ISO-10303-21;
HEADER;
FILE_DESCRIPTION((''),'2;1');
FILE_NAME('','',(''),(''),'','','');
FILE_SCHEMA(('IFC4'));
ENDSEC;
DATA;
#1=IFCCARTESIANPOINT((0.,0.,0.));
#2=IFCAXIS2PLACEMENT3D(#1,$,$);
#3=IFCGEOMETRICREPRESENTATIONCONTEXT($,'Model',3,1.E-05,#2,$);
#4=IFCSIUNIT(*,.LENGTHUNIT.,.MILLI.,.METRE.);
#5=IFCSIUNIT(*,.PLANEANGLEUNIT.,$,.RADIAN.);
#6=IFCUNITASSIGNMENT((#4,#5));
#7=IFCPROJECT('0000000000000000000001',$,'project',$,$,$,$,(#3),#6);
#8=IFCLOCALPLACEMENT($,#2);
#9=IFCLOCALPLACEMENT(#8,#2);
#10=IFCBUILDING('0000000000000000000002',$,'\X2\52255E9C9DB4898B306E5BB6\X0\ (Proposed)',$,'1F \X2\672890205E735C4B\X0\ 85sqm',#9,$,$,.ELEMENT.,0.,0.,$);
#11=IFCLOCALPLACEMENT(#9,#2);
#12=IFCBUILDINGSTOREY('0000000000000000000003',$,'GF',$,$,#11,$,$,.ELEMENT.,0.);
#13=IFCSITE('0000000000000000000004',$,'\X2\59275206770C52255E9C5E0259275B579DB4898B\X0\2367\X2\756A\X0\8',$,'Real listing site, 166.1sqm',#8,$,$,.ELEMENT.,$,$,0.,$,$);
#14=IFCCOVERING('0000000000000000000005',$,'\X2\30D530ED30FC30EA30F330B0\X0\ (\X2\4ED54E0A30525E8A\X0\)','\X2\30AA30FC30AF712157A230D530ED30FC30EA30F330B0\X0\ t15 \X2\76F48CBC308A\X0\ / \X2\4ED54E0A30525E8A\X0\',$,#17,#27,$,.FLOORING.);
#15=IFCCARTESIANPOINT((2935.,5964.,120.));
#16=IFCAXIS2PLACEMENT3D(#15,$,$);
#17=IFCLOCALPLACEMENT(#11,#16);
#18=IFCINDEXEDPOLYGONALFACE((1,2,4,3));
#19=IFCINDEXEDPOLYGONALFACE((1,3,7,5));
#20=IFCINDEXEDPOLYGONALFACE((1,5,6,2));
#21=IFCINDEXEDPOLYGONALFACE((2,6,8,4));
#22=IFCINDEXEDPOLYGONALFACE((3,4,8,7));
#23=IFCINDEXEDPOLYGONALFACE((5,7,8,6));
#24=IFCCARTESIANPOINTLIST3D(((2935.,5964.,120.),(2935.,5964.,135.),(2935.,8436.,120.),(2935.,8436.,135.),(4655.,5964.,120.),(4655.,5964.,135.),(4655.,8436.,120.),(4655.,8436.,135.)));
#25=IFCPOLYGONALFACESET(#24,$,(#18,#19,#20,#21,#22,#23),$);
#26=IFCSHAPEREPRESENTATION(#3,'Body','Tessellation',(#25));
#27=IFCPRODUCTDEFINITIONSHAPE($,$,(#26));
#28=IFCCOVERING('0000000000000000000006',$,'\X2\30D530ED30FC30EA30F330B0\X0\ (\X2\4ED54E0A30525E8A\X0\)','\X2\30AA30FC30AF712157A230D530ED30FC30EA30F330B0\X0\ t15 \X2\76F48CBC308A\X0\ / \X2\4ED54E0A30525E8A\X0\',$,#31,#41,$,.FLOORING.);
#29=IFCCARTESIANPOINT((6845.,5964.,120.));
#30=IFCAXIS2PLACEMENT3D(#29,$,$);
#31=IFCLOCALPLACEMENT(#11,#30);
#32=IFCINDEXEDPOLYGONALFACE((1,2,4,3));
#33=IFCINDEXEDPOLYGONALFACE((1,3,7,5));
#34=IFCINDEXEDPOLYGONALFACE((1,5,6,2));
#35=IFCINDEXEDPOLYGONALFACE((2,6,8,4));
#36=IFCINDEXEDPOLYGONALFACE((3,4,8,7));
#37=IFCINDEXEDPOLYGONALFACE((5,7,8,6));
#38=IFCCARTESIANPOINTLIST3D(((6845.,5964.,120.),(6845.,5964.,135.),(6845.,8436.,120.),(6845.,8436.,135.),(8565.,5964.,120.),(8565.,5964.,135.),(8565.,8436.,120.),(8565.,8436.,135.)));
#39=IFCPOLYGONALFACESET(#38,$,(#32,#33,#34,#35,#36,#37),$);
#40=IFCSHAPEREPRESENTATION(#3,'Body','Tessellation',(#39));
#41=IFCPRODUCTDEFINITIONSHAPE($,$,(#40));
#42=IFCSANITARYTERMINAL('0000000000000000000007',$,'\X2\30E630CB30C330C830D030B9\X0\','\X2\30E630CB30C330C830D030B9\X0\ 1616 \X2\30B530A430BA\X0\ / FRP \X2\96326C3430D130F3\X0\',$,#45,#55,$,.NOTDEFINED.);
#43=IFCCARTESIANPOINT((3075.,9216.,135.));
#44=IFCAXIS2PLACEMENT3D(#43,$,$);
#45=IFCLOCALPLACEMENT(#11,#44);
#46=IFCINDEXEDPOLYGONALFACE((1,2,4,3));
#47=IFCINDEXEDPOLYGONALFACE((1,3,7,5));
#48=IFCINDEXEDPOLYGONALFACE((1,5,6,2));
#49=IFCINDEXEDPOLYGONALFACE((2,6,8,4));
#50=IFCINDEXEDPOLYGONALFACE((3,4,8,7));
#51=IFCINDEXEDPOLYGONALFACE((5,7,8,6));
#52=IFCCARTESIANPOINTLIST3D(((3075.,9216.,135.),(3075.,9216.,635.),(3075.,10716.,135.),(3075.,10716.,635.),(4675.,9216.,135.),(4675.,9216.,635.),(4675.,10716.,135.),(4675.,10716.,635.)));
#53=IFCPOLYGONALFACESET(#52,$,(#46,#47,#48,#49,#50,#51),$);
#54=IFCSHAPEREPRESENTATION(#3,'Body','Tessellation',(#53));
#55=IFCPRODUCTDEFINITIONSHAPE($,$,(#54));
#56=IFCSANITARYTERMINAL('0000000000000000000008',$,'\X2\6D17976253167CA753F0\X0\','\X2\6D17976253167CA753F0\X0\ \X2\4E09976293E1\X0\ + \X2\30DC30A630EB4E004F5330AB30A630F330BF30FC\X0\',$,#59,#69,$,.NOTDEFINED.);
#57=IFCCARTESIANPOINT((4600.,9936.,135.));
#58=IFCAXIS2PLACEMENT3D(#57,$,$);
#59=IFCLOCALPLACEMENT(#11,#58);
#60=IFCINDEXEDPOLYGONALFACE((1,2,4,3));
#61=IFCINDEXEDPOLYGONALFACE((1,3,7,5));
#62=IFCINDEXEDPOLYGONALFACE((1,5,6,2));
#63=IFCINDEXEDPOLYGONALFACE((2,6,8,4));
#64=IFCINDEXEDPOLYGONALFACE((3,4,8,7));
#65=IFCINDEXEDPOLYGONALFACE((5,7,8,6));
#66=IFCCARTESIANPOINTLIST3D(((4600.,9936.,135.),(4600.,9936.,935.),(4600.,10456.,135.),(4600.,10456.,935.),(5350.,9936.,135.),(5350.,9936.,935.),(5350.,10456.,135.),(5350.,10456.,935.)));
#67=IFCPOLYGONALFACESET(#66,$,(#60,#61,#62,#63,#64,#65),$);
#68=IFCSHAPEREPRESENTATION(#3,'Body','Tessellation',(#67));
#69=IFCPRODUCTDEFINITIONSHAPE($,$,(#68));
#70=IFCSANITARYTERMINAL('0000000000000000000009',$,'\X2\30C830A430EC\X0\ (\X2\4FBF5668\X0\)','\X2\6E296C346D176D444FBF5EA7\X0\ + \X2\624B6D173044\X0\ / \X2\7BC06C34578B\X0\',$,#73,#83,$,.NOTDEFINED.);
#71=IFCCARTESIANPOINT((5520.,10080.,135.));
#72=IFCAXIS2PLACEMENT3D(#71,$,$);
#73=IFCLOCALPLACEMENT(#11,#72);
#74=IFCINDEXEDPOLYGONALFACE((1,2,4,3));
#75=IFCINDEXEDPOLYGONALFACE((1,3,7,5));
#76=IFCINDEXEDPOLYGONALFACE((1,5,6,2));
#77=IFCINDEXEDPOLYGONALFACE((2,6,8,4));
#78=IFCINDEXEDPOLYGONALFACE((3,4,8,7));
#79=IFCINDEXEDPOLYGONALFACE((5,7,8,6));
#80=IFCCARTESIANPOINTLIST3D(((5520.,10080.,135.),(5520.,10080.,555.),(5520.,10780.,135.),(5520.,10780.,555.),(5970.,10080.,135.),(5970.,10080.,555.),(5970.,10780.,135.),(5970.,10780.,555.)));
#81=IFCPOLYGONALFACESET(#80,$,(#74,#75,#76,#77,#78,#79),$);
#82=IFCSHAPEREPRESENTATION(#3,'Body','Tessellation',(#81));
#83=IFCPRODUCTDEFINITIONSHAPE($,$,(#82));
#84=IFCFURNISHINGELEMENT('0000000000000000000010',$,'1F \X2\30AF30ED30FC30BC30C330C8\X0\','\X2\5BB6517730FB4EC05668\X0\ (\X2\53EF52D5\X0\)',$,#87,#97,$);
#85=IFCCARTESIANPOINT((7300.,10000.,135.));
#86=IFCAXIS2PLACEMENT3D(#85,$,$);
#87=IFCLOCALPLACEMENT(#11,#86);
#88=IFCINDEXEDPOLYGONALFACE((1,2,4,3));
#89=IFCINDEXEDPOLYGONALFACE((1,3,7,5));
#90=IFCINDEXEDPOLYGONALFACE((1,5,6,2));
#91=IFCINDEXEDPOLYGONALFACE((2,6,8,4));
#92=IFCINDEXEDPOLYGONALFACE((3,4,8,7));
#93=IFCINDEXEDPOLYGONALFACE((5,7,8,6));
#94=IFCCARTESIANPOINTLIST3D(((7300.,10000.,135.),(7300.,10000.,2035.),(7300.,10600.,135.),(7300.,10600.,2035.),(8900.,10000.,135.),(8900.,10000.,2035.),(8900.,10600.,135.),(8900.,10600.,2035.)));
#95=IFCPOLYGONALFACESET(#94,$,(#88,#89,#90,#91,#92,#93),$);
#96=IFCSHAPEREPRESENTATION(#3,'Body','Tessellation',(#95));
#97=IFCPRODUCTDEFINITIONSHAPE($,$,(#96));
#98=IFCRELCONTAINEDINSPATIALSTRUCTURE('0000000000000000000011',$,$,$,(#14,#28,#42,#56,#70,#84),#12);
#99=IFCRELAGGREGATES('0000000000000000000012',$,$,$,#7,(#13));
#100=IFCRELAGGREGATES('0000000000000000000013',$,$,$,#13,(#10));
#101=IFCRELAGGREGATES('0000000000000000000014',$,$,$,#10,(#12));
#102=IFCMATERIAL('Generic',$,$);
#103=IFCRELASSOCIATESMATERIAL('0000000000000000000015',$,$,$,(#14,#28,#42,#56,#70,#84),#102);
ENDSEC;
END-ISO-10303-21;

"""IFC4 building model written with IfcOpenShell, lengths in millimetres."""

from ifc_helpers import new_model, si_unit, frame, frame_2d, origin, place, context, project, spatial, rectangle, extrude, material, element, save


model = new_model("IFC4")

# Units and contexts
model_context = context("Model", 3, precision=1e-05, world=origin())
ifc_project = project(units=[si_unit("LENGTHUNIT", "METRE", prefix="MILLI"), si_unit("PLANEANGLEUNIT", "RADIAN")], contexts=[model_context])

# Site, building, storey
site_placement = place(None, origin())
site = spatial("IfcSite", under=ifc_project, at=site_placement, Name="大分県別府市大字鶴見2367番8", ObjectType="Real listing site, 166.1sqm", CompositionType="ELEMENT", RefElevation=0.0)
building_placement = place(site_placement, origin())
building = spatial("IfcBuilding", under=site, at=building_placement, Name="別府鶴見の家 (Proposed)", ObjectType="1F 木造平屋 85sqm", CompositionType="ELEMENT", ElevationOfRefHeight=0.0, ElevationOfTerrain=0.0)
storey_placement = place(building_placement, origin())
storey = spatial("IfcBuildingStorey", under=building, at=storey_placement, Name="GF", CompositionType="ELEMENT", Elevation=0.0)

# Coverings
ifc_material_1 = material(Name="Generic")
covering_1_placement = place(storey_placement, frame((2935.0, 5964.0, 120.0)))
element("IfcCovering", 1, at=covering_1_placement, inside=storey, material=ifc_material_1, Name="フローリング (仕上げ床)", Description="オーク無垢フローリング t15 直貼り / 仕上げ床", PredefinedType="FLOORING", context=model_context, shape_type="SweptSolid", body=[
    extrude(rectangle(XDim=1720.0, YDim=2472.0, at=frame_2d((860.0, 1236.0))), frame((2935.0, 5964.0, 120.0)), (0.0, 0.0, 1.0), 15.0),
])
covering_2_placement = place(storey_placement, frame((6845.0, 5964.0, 120.0)))
element("IfcCovering", 2, at=covering_2_placement, inside=storey, material=ifc_material_1, Name="フローリング (仕上げ床)", Description="オーク無垢フローリング t15 直貼り / 仕上げ床", PredefinedType="FLOORING", context=model_context, shape_type="SweptSolid", body=[
    extrude(rectangle(XDim=1720.0, YDim=2472.0, at=frame_2d((860.0, 1236.0))), frame((6845.0, 5964.0, 120.0)), (0.0, 0.0, 1.0), 15.0),
])

# Sanitary terminals
sanitary_terminal_1_placement = place(storey_placement, frame((3075.0, 9216.0, 135.0)))
element("IfcSanitaryTerminal", 3, at=sanitary_terminal_1_placement, inside=storey, material=ifc_material_1, Name="ユニットバス", Description="ユニットバス 1616 サイズ / FRP 防水パン", PredefinedType="NOTDEFINED", context=model_context, shape_type="SweptSolid", body=[
    extrude(rectangle(XDim=1600.0, YDim=1500.0, at=frame_2d((800.0, 750.0))), frame((3075.0, 9216.0, 135.0)), (0.0, 0.0, 1.0), 500.0),
])
sanitary_terminal_2_placement = place(storey_placement, frame((4600.0, 9936.0, 135.0)))
element("IfcSanitaryTerminal", 4, at=sanitary_terminal_2_placement, inside=storey, material=ifc_material_1, Name="洗面化粧台", Description="洗面化粧台 三面鏡 + ボウル一体カウンター", PredefinedType="NOTDEFINED", context=model_context, shape_type="SweptSolid", body=[
    extrude(rectangle(XDim=750.0, YDim=520.0, at=frame_2d((375.0, 260.0))), frame((4600.0, 9936.0, 135.0)), (0.0, 0.0, 1.0), 800.0),
])
sanitary_terminal_3_placement = place(storey_placement, frame((5520.0, 10080.0, 135.0)))
element("IfcSanitaryTerminal", 5, at=sanitary_terminal_3_placement, inside=storey, material=ifc_material_1, Name="トイレ (便器)", Description="温水洗浄便座 + 手洗い / 節水型", PredefinedType="NOTDEFINED", context=model_context, shape_type="SweptSolid", body=[
    extrude(rectangle(XDim=450.0, YDim=700.0, at=frame_2d((225.0, 350.0))), frame((5520.0, 10080.0, 135.0)), (0.0, 0.0, 1.0), 420.0),
])

# Furnishing element
furnishing_placement = place(storey_placement, frame((7300.0, 10000.0, 135.0)))
element("IfcFurnishingElement", 6, at=furnishing_placement, inside=storey, material=ifc_material_1, Name="1F クローゼット", Description="家具・什器 (可動)", context=model_context, shape_type="SweptSolid", body=[
    extrude(rectangle(XDim=1600.0, YDim=600.0, at=frame_2d((800.0, 300.0))), frame((7300.0, 10000.0, 135.0)), (0.0, 0.0, 1.0), 1900.0),
])

save(model, "model.ifc")
